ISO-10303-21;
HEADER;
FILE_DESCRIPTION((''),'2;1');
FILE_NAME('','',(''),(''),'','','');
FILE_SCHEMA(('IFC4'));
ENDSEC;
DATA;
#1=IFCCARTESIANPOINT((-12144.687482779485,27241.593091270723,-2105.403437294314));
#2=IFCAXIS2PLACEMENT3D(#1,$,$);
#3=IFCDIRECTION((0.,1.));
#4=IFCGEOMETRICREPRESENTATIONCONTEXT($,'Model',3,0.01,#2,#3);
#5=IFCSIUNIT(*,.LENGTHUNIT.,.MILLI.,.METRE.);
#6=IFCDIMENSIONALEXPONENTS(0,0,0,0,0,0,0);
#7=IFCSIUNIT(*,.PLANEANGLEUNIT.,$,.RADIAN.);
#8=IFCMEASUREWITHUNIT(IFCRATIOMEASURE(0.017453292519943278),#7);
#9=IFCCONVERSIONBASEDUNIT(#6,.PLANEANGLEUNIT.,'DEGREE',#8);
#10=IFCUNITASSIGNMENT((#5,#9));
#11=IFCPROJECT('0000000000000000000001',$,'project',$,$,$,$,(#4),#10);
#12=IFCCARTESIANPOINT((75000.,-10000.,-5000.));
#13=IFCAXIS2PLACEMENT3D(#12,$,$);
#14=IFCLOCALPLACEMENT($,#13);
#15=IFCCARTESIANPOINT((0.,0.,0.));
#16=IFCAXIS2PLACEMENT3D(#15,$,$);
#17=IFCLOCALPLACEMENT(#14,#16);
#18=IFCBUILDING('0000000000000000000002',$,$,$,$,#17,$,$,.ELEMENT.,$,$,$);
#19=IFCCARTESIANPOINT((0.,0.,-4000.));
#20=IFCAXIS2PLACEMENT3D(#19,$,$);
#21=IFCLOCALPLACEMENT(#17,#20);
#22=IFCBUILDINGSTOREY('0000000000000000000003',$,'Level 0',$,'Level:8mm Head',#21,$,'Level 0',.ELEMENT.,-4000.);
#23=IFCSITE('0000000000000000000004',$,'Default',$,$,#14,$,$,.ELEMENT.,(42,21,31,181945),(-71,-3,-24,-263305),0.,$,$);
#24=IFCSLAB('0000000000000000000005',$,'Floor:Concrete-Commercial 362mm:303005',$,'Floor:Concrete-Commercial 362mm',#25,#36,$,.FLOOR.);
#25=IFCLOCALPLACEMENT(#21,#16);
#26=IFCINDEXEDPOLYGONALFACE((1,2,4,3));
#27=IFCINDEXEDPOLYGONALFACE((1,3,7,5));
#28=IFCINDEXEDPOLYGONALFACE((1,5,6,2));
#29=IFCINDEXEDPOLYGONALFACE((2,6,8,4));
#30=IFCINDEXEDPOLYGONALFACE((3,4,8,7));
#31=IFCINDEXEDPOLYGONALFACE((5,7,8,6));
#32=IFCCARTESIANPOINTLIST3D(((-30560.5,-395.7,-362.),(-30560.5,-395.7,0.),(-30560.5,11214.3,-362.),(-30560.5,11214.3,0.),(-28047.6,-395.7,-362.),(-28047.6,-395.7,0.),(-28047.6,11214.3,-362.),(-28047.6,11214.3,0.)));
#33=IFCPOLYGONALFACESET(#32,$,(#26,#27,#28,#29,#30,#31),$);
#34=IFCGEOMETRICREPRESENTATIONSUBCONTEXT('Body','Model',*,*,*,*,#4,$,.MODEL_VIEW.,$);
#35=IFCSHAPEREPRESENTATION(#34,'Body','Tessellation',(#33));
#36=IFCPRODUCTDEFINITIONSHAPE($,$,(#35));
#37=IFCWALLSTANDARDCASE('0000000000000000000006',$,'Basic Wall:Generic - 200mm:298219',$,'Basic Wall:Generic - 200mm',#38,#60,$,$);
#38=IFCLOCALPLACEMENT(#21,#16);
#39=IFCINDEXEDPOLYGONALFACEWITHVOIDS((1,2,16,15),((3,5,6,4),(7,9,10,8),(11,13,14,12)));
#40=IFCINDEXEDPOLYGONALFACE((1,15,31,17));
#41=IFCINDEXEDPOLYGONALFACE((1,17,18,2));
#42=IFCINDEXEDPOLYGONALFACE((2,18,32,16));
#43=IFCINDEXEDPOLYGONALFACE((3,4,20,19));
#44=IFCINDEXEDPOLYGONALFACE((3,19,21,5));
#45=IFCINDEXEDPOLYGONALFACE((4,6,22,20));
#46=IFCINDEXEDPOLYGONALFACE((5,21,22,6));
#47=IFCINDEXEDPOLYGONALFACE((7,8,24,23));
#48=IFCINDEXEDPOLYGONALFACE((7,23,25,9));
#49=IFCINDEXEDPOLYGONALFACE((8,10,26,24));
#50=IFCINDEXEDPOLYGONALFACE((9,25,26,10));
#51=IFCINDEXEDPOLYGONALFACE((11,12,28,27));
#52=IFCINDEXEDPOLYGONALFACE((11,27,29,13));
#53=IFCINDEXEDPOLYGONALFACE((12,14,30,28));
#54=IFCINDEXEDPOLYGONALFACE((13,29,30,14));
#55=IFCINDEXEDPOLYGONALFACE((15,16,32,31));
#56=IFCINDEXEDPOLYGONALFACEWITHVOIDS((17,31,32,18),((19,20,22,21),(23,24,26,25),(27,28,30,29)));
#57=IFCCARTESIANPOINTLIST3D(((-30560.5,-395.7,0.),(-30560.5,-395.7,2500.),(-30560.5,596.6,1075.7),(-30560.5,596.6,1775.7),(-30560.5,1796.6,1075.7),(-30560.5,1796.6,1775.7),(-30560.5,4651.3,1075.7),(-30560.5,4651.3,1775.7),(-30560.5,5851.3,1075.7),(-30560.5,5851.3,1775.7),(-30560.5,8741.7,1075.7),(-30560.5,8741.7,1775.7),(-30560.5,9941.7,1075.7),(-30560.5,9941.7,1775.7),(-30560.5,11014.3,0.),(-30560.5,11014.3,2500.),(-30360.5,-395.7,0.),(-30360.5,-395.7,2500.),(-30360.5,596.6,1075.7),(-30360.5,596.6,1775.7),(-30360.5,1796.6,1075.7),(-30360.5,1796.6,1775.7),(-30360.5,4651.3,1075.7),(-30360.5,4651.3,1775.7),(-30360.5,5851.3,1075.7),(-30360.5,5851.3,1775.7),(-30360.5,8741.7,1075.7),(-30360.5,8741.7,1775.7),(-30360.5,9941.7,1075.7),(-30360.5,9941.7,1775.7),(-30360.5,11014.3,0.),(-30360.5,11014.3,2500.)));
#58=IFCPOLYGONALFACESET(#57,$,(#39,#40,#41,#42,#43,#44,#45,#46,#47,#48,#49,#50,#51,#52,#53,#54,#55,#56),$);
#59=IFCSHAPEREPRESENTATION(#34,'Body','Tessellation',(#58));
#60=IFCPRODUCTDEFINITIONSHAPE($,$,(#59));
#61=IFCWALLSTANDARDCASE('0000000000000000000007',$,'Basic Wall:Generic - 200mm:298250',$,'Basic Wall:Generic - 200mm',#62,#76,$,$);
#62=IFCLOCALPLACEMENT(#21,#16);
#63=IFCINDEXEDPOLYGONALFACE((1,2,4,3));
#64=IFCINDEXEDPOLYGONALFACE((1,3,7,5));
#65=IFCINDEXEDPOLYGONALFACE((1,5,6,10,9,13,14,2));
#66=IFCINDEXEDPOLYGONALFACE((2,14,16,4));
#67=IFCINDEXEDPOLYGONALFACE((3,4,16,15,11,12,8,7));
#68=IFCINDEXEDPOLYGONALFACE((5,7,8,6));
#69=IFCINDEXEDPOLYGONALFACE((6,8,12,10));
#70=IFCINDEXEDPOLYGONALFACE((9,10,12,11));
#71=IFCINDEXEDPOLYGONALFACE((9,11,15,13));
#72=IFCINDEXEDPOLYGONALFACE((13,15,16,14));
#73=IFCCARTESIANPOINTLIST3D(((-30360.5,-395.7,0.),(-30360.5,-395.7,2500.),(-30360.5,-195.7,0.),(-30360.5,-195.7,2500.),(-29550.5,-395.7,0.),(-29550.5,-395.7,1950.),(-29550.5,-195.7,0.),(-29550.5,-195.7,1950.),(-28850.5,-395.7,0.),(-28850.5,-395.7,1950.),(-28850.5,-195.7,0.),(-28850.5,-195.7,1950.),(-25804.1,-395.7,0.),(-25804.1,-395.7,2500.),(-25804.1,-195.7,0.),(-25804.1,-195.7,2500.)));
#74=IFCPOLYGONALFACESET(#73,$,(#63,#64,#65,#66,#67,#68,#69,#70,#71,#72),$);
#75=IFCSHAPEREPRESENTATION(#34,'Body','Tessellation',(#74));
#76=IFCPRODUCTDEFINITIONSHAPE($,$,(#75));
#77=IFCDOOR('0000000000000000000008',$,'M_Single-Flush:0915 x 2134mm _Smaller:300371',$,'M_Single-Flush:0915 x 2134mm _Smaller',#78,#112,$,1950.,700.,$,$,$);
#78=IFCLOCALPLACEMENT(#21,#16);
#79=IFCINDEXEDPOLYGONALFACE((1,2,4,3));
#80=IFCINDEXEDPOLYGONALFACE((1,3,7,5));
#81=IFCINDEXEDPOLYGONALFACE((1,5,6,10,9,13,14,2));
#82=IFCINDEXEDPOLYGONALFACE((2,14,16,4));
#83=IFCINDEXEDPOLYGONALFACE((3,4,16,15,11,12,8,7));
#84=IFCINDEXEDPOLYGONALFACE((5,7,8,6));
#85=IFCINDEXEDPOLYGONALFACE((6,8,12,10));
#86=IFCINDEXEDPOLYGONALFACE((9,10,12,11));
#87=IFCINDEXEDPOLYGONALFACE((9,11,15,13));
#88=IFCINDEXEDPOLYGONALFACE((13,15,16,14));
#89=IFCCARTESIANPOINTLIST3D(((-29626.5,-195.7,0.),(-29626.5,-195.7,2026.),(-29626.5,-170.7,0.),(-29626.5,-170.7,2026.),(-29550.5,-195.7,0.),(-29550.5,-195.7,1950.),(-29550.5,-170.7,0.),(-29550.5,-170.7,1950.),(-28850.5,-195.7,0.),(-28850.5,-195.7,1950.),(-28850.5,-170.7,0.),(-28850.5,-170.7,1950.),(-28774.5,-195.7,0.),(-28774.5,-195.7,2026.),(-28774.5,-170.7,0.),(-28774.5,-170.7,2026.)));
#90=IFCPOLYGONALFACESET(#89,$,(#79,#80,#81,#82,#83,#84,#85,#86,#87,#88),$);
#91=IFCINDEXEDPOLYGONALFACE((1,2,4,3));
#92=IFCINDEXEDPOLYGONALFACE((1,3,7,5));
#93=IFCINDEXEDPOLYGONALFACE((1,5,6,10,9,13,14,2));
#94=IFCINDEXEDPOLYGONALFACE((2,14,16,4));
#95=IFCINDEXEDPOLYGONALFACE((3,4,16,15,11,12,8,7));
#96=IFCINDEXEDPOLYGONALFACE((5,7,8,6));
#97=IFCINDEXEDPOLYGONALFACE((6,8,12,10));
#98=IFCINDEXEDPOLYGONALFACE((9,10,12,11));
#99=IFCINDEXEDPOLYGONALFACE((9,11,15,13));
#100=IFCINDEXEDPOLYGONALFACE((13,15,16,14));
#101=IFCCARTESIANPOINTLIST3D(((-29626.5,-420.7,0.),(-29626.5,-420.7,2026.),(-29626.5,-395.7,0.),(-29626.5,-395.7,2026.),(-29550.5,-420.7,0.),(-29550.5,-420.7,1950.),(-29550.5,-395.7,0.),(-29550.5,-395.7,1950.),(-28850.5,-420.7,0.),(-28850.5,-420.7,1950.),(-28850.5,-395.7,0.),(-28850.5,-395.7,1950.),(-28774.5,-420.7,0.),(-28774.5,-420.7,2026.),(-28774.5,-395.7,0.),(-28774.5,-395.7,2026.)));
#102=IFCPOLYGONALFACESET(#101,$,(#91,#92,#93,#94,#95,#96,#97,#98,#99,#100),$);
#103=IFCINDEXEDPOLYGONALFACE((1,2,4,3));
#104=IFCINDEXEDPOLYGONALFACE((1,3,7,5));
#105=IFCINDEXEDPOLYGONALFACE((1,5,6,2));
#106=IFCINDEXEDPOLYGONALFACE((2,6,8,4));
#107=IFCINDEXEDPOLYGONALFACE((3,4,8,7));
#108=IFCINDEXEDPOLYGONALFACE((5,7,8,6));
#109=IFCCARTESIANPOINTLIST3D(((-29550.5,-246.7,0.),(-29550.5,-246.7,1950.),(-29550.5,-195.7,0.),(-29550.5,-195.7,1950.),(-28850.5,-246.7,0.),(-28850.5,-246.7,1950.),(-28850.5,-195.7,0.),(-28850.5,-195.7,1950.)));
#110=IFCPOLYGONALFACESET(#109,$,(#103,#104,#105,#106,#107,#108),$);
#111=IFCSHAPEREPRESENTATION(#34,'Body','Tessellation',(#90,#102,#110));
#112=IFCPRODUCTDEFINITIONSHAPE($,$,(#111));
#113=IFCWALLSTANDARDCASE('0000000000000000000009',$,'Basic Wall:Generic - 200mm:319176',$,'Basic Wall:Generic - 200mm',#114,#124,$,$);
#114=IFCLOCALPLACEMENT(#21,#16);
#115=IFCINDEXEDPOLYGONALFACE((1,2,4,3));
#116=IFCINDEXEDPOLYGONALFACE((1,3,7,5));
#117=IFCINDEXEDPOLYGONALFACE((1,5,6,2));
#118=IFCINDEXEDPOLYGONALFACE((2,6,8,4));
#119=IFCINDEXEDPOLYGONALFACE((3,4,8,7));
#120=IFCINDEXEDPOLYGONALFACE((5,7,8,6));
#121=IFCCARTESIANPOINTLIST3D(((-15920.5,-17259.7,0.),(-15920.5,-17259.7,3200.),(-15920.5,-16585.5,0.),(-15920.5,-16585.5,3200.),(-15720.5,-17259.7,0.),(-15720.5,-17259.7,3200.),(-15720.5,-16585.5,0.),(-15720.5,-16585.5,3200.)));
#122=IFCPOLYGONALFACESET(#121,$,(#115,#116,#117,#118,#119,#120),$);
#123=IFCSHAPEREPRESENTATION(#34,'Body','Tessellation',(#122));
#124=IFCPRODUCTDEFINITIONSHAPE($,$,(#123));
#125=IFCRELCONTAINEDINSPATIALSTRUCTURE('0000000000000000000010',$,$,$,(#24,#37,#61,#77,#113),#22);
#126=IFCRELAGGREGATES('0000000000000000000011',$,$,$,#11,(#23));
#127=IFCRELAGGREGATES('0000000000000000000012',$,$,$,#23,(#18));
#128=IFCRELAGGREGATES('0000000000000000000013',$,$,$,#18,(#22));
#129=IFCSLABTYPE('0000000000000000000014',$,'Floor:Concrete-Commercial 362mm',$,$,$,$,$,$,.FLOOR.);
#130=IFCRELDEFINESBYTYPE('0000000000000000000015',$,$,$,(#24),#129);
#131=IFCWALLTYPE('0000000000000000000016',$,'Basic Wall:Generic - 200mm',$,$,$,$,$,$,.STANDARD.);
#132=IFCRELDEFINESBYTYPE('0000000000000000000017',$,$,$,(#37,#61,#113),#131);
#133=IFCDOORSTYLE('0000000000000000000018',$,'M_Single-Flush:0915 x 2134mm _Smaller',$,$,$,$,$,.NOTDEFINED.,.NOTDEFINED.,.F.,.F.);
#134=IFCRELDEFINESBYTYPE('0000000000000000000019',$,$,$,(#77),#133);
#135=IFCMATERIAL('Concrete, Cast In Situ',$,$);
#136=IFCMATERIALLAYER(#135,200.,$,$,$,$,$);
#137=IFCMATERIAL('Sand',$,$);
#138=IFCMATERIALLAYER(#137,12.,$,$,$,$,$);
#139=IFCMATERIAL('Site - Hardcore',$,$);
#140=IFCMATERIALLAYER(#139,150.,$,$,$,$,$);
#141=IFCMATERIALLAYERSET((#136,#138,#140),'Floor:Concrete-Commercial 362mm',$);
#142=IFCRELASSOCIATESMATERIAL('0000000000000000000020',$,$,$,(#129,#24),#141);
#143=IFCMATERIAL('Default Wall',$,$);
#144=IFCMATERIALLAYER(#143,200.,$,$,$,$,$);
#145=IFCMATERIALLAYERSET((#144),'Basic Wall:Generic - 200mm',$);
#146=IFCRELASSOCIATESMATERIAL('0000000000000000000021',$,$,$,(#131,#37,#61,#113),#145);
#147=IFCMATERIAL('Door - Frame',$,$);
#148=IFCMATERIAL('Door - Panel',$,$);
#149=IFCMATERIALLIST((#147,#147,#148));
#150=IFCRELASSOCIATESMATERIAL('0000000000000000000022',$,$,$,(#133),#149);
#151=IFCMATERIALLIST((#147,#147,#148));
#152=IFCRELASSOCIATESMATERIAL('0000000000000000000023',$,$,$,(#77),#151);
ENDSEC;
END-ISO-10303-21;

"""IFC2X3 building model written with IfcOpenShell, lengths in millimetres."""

from ifc_helpers import new_model, entity, si_unit, converted_unit, direction, frame, frame_2d, origin, origin_2d_with_axis, place, context, subcontext, project, spatial, polyline, rectangle, outline, extrude, clip, bounded_halfspace, source, transform, mapped, material, material_list, layer, layer_set, layer_usage, type_object, type_shapes, element, fill, save


model = new_model("IFC2X3")

# Units and contexts
model_context = context("Model", 3, precision=0.01, world=frame((-12144.687482779485, 27241.593091270723, -2105.403437294314)), true_north=direction((0.0, 1.0)))
body_context = subcontext(model_context, "Body", "Model", "MODEL_VIEW")
ifc_project = project(units=[si_unit("LENGTHUNIT", "METRE", prefix="MILLI"), converted_unit("PLANEANGLEUNIT", "DEGREE", entity("IfcRatioMeasure", 0.017453292519943278), si_unit("PLANEANGLEUNIT", "RADIAN"), dimensions=[0, 0, 0, 0, 0, 0, 0])], contexts=[model_context])

# Site, building, storey
site_placement = place(None, frame((75000.0, -10000.0, -5000.0)))
site = spatial("IfcSite", under=ifc_project, at=site_placement, Name="Default", CompositionType="ELEMENT", RefLatitude=(42, 21, 31, 181945), RefLongitude=(-71, -3, -24, -263305), RefElevation=0.0)
building_placement = place(site_placement, origin())
building = spatial("IfcBuilding", under=site, at=building_placement, CompositionType="ELEMENT")
storey_placement = place(building_placement, frame((0.0, 0.0, -4000.0)))
storey = spatial("IfcBuildingStorey", under=building, at=storey_placement, Name="Level 0", ObjectType="Level:8mm Head", LongName="Level 0", CompositionType="ELEMENT", Elevation=-4000.0)

# Slab
ifc_material_1 = material(Name="Concrete, Cast In Situ")
ifc_layer_1 = layer(ifc_material_1, 200.0)
ifc_material_2 = material(Name="Sand")
ifc_layer_2 = layer(ifc_material_2, 12.0)
ifc_material_3 = material(Name="Site - Hardcore")
ifc_layer_3 = layer(ifc_material_3, 150.0)
ifc_layer_set_1 = layer_set([ifc_layer_1, ifc_layer_2, ifc_layer_3], Name="Floor:Concrete-Commercial 362mm")
ifc_layer_usage_1 = layer_usage(ifc_layer_set_1, "AXIS3", "POSITIVE", 0.0)
slab_type = type_object("IfcSlabType", Name="Floor:Concrete-Commercial 362mm", PredefinedType="FLOOR", material=ifc_layer_set_1)
slab_placement = place(storey_placement, origin())
element("IfcSlab", 1, at=slab_placement, inside=storey, type_object=slab_type, material=ifc_layer_usage_1, Name="Floor:Concrete-Commercial 362mm:303005", ObjectType="Floor:Concrete-Commercial 362mm", PredefinedType="FLOOR", context=body_context, shape_type="SweptSolid", body=[
    extrude(rectangle(XDim=11610.0, YDim=2512.8, at=origin_2d_with_axis()), frame((-29304.1, 5409.3, 0.0), z_axis=(0.0, 0.0, -1.0), x_axis=(0.0, 1.0, 0.0)), (0.0, 0.0, 1.0), 362.0),
])

# Shared definitions
ifc_material_4 = material(Name="Default Wall")
ifc_layer_4 = layer(ifc_material_4, 200.0)
ifc_layer_set_2 = layer_set([ifc_layer_4], Name="Basic Wall:Generic - 200mm")
wall_type = type_object("IfcWallType", Name="Basic Wall:Generic - 200mm", PredefinedType="STANDARD", material=ifc_layer_set_2)

# Wall, openings
ifc_layer_usage_2 = layer_usage(ifc_layer_set_2, "AXIS2", "NEGATIVE", 100.0)
wall_1_placement = place(storey_placement, frame((-30460.5, 11014.3, 0.0), z_axis=(0.0, 0.0, 1.0), x_axis=(0.0, -1.0, 0.0)))
wall_1 = element("IfcWallStandardCase", 2, at=wall_1_placement, inside=storey, type_object=wall_type, material=ifc_layer_usage_2, Name="Basic Wall:Generic - 200mm:298219", ObjectType="Basic Wall:Generic - 200mm", context=body_context, shape_type="Clipping", body=[
    clip(extrude(rectangle(XDim=11410.0, YDim=200.0, at=frame_2d((5705.0, 0.0), x_axis=(-1.0, 0.0))), origin(), (0.0, 0.0, 1.0), 2500.0), bounded_halfspace(frame((0.0, -100.0, 2500.0), z_axis=(0.0, 0.0, -1.0), x_axis=(0.0, 1.0, 0.0)), True, frame((0.0, -100.0, 2500.0)), polyline([(0.0, 0.0), (3477782.0, 0.0), (3477782.0, 60960.0), (3416822.0, 60960.0), (0.0, 60960.0), (0.0, 0.0)]))),
])
opening_1_placement = place(wall_1_placement, frame((1072.6, -100.0, 1075.7)))
element("IfcOpeningElement", 3, at=opening_1_placement, cuts=wall_1, ObjectType="Opening", context=body_context, shape_type="SweptSolid", body=[
    extrude(rectangle(XDim=700.0, YDim=1200.0, at=frame_2d((350.0, 600.0), x_axis=(-1.0, 0.0))), frame((0.0, 0.0, 0.0), z_axis=(0.0, 1.0, 0.0), x_axis=(0.0, 0.0, 1.0)), (0.0, 0.0, 1.0), 200.0),
])
opening_2_placement = place(wall_1_placement, frame((5163.0, -100.0, 1075.7)))
element("IfcOpeningElement", 4, at=opening_2_placement, cuts=wall_1, ObjectType="Opening", context=body_context, shape_type="SweptSolid", body=[
    extrude(rectangle(XDim=700.0, YDim=1200.0, at=frame_2d((350.0, 600.0), x_axis=(-1.0, 0.0))), frame((0.0, 0.0, 0.0), z_axis=(0.0, 1.0, 0.0), x_axis=(0.0, 0.0, 1.0)), (0.0, 0.0, 1.0), 200.0),
])
opening_3_placement = place(wall_1_placement, frame((9217.8, -100.0, 1075.7)))
element("IfcOpeningElement", 5, at=opening_3_placement, cuts=wall_1, ObjectType="Opening", context=body_context, shape_type="SweptSolid", body=[
    extrude(rectangle(XDim=700.0, YDim=1200.0, at=frame_2d((350.0, 600.0), x_axis=(-1.0, 0.0))), frame((0.0, 0.0, 0.0), z_axis=(0.0, 1.0, 0.0), x_axis=(0.0, 0.0, 1.0)), (0.0, 0.0, 1.0), 200.0),
])

# Wall, opening, door
ifc_layer_usage_3 = layer_usage(ifc_layer_set_2, "AXIS2", "NEGATIVE", 100.0)
wall_2_placement = place(storey_placement, frame((-30360.5, -295.7, 0.0)))
wall_2 = element("IfcWallStandardCase", 6, at=wall_2_placement, inside=storey, type_object=wall_type, material=ifc_layer_usage_3, Name="Basic Wall:Generic - 200mm:298250", ObjectType="Basic Wall:Generic - 200mm", context=body_context, shape_type="Clipping", body=[
    clip(extrude(rectangle(XDim=200.0, YDim=4556.4, at=frame_2d((2278.2, 0.0), x_axis=(0.0, -1.0))), origin(), (0.0, 0.0, 1.0), 2500.0), bounded_halfspace(frame((0.0, 100.0, 2500.0), z_axis=(0.0, 0.0, -1.0), x_axis=(1.0, 0.0, 0.0)), True, frame((0.0, 100.0, 2500.0)), polyline([(0.0, 0.0), (0.0, -60960.0), (1388794.7, -60960.0), (1388794.7, 0.0), (0.0, 0.0)]))),
])
opening_4_placement = place(wall_2_placement, frame((810.0, -100.0, 0.0)))
opening_4 = element("IfcOpeningElement", 7, at=opening_4_placement, cuts=wall_2, ObjectType="Opening", context=body_context, shape_type="SweptSolid", body=[
    extrude(rectangle(XDim=700.0, YDim=1950.0, at=frame_2d((975.0, 350.0), x_axis=(0.0, -1.0))), frame((0.0, 0.0, 0.0), z_axis=(0.0, 1.0, 0.0), x_axis=(0.0, 0.0, 1.0)), (0.0, 0.0, 1.0), 200.0),
])
ifc_material_5 = material(Name="Door - Frame")
ifc_material_6 = material(Name="Door - Panel")
ifc_material_list_1 = material_list([ifc_material_5, ifc_material_5, ifc_material_6])
ifc_material_list_2 = material_list([ifc_material_5, ifc_material_5, ifc_material_6])
door_style = type_object("IfcDoorStyle", Name="M_Single-Flush:0915 x 2134mm _Smaller", ConstructionType="NOTDEFINED", OperationType="NOTDEFINED", ParameterTakesPrecedence=False, Sizeable=False, material=ifc_material_list_2)
shared_shape = source(origin(), body_context, "Body", "SweptSolid", [
    extrude(outline(polyline([(-426.0, -1032.0), (426.0, -1032.0), (426.0, 994.0), (350.0, 994.0), (350.0, -956.0), (-350.0, -956.0), (-350.0, 994.0), (-426.0, 994.0), (-426.0, -1032.0)])), frame((350.0, 225.0, 994.0), z_axis=(0.0, -1.0, 0.0), x_axis=(-1.0, 0.0, 0.0)), (0.0, 0.0, 1.0), 25.0),
    extrude(outline(polyline([(-1032.0, -426.0), (994.0, -426.0), (994.0, -350.0), (-956.0, -350.0), (-956.0, 350.0), (994.0, 350.0), (994.0, 426.0), (-1032.0, 426.0), (-1032.0, -426.0)])), frame((350.0, 0.0, 994.0), z_axis=(0.0, -1.0, 0.0), x_axis=(0.0, 0.0, -1.0)), (0.0, 0.0, 1.0), 25.0),
    extrude(rectangle(XDim=700.0, YDim=51.0, at=frame_2d((0.0, 0.0), x_axis=(1.0, 0.0))), frame((350.0, 174.5, 0.0)), (0.0, 0.0, 1.0), 1950.0),
])
type_shapes(door_style, [shared_shape])
door_placement = place(opening_4_placement, origin())
door = element("IfcDoor", 8, at=door_placement, inside=storey, type_object=door_style, material=ifc_material_list_1, Name="M_Single-Flush:0915 x 2134mm _Smaller:300371", ObjectType="M_Single-Flush:0915 x 2134mm _Smaller", OverallHeight=1950.0, OverallWidth=700.0, context=body_context, shape_type="MappedRepresentation", body=[
    mapped(shared_shape, transform((0.0, 0.0, 0.0), scale=1.0)),
])
fill(opening_4, door)

# Wall
ifc_layer_usage_4 = layer_usage(ifc_layer_set_2, "AXIS2", "NEGATIVE", 100.0)
wall_3_placement = place(storey_placement, frame((-15820.5, -16585.5, 0.0), z_axis=(0.0, 0.0, 1.0), x_axis=(0.0, -1.0, 0.0)))
element("IfcWallStandardCase", 9, at=wall_3_placement, inside=storey, type_object=wall_type, material=ifc_layer_usage_4, Name="Basic Wall:Generic - 200mm:319176", ObjectType="Basic Wall:Generic - 200mm", context=body_context, shape_type="SweptSolid", body=[
    extrude(rectangle(XDim=674.2, YDim=200.0, at=frame_2d((337.1, 0.0), x_axis=(-1.0, 0.0))), origin(), (0.0, 0.0, 1.0), 3200.0),
])

save(model, "model.ifc")
